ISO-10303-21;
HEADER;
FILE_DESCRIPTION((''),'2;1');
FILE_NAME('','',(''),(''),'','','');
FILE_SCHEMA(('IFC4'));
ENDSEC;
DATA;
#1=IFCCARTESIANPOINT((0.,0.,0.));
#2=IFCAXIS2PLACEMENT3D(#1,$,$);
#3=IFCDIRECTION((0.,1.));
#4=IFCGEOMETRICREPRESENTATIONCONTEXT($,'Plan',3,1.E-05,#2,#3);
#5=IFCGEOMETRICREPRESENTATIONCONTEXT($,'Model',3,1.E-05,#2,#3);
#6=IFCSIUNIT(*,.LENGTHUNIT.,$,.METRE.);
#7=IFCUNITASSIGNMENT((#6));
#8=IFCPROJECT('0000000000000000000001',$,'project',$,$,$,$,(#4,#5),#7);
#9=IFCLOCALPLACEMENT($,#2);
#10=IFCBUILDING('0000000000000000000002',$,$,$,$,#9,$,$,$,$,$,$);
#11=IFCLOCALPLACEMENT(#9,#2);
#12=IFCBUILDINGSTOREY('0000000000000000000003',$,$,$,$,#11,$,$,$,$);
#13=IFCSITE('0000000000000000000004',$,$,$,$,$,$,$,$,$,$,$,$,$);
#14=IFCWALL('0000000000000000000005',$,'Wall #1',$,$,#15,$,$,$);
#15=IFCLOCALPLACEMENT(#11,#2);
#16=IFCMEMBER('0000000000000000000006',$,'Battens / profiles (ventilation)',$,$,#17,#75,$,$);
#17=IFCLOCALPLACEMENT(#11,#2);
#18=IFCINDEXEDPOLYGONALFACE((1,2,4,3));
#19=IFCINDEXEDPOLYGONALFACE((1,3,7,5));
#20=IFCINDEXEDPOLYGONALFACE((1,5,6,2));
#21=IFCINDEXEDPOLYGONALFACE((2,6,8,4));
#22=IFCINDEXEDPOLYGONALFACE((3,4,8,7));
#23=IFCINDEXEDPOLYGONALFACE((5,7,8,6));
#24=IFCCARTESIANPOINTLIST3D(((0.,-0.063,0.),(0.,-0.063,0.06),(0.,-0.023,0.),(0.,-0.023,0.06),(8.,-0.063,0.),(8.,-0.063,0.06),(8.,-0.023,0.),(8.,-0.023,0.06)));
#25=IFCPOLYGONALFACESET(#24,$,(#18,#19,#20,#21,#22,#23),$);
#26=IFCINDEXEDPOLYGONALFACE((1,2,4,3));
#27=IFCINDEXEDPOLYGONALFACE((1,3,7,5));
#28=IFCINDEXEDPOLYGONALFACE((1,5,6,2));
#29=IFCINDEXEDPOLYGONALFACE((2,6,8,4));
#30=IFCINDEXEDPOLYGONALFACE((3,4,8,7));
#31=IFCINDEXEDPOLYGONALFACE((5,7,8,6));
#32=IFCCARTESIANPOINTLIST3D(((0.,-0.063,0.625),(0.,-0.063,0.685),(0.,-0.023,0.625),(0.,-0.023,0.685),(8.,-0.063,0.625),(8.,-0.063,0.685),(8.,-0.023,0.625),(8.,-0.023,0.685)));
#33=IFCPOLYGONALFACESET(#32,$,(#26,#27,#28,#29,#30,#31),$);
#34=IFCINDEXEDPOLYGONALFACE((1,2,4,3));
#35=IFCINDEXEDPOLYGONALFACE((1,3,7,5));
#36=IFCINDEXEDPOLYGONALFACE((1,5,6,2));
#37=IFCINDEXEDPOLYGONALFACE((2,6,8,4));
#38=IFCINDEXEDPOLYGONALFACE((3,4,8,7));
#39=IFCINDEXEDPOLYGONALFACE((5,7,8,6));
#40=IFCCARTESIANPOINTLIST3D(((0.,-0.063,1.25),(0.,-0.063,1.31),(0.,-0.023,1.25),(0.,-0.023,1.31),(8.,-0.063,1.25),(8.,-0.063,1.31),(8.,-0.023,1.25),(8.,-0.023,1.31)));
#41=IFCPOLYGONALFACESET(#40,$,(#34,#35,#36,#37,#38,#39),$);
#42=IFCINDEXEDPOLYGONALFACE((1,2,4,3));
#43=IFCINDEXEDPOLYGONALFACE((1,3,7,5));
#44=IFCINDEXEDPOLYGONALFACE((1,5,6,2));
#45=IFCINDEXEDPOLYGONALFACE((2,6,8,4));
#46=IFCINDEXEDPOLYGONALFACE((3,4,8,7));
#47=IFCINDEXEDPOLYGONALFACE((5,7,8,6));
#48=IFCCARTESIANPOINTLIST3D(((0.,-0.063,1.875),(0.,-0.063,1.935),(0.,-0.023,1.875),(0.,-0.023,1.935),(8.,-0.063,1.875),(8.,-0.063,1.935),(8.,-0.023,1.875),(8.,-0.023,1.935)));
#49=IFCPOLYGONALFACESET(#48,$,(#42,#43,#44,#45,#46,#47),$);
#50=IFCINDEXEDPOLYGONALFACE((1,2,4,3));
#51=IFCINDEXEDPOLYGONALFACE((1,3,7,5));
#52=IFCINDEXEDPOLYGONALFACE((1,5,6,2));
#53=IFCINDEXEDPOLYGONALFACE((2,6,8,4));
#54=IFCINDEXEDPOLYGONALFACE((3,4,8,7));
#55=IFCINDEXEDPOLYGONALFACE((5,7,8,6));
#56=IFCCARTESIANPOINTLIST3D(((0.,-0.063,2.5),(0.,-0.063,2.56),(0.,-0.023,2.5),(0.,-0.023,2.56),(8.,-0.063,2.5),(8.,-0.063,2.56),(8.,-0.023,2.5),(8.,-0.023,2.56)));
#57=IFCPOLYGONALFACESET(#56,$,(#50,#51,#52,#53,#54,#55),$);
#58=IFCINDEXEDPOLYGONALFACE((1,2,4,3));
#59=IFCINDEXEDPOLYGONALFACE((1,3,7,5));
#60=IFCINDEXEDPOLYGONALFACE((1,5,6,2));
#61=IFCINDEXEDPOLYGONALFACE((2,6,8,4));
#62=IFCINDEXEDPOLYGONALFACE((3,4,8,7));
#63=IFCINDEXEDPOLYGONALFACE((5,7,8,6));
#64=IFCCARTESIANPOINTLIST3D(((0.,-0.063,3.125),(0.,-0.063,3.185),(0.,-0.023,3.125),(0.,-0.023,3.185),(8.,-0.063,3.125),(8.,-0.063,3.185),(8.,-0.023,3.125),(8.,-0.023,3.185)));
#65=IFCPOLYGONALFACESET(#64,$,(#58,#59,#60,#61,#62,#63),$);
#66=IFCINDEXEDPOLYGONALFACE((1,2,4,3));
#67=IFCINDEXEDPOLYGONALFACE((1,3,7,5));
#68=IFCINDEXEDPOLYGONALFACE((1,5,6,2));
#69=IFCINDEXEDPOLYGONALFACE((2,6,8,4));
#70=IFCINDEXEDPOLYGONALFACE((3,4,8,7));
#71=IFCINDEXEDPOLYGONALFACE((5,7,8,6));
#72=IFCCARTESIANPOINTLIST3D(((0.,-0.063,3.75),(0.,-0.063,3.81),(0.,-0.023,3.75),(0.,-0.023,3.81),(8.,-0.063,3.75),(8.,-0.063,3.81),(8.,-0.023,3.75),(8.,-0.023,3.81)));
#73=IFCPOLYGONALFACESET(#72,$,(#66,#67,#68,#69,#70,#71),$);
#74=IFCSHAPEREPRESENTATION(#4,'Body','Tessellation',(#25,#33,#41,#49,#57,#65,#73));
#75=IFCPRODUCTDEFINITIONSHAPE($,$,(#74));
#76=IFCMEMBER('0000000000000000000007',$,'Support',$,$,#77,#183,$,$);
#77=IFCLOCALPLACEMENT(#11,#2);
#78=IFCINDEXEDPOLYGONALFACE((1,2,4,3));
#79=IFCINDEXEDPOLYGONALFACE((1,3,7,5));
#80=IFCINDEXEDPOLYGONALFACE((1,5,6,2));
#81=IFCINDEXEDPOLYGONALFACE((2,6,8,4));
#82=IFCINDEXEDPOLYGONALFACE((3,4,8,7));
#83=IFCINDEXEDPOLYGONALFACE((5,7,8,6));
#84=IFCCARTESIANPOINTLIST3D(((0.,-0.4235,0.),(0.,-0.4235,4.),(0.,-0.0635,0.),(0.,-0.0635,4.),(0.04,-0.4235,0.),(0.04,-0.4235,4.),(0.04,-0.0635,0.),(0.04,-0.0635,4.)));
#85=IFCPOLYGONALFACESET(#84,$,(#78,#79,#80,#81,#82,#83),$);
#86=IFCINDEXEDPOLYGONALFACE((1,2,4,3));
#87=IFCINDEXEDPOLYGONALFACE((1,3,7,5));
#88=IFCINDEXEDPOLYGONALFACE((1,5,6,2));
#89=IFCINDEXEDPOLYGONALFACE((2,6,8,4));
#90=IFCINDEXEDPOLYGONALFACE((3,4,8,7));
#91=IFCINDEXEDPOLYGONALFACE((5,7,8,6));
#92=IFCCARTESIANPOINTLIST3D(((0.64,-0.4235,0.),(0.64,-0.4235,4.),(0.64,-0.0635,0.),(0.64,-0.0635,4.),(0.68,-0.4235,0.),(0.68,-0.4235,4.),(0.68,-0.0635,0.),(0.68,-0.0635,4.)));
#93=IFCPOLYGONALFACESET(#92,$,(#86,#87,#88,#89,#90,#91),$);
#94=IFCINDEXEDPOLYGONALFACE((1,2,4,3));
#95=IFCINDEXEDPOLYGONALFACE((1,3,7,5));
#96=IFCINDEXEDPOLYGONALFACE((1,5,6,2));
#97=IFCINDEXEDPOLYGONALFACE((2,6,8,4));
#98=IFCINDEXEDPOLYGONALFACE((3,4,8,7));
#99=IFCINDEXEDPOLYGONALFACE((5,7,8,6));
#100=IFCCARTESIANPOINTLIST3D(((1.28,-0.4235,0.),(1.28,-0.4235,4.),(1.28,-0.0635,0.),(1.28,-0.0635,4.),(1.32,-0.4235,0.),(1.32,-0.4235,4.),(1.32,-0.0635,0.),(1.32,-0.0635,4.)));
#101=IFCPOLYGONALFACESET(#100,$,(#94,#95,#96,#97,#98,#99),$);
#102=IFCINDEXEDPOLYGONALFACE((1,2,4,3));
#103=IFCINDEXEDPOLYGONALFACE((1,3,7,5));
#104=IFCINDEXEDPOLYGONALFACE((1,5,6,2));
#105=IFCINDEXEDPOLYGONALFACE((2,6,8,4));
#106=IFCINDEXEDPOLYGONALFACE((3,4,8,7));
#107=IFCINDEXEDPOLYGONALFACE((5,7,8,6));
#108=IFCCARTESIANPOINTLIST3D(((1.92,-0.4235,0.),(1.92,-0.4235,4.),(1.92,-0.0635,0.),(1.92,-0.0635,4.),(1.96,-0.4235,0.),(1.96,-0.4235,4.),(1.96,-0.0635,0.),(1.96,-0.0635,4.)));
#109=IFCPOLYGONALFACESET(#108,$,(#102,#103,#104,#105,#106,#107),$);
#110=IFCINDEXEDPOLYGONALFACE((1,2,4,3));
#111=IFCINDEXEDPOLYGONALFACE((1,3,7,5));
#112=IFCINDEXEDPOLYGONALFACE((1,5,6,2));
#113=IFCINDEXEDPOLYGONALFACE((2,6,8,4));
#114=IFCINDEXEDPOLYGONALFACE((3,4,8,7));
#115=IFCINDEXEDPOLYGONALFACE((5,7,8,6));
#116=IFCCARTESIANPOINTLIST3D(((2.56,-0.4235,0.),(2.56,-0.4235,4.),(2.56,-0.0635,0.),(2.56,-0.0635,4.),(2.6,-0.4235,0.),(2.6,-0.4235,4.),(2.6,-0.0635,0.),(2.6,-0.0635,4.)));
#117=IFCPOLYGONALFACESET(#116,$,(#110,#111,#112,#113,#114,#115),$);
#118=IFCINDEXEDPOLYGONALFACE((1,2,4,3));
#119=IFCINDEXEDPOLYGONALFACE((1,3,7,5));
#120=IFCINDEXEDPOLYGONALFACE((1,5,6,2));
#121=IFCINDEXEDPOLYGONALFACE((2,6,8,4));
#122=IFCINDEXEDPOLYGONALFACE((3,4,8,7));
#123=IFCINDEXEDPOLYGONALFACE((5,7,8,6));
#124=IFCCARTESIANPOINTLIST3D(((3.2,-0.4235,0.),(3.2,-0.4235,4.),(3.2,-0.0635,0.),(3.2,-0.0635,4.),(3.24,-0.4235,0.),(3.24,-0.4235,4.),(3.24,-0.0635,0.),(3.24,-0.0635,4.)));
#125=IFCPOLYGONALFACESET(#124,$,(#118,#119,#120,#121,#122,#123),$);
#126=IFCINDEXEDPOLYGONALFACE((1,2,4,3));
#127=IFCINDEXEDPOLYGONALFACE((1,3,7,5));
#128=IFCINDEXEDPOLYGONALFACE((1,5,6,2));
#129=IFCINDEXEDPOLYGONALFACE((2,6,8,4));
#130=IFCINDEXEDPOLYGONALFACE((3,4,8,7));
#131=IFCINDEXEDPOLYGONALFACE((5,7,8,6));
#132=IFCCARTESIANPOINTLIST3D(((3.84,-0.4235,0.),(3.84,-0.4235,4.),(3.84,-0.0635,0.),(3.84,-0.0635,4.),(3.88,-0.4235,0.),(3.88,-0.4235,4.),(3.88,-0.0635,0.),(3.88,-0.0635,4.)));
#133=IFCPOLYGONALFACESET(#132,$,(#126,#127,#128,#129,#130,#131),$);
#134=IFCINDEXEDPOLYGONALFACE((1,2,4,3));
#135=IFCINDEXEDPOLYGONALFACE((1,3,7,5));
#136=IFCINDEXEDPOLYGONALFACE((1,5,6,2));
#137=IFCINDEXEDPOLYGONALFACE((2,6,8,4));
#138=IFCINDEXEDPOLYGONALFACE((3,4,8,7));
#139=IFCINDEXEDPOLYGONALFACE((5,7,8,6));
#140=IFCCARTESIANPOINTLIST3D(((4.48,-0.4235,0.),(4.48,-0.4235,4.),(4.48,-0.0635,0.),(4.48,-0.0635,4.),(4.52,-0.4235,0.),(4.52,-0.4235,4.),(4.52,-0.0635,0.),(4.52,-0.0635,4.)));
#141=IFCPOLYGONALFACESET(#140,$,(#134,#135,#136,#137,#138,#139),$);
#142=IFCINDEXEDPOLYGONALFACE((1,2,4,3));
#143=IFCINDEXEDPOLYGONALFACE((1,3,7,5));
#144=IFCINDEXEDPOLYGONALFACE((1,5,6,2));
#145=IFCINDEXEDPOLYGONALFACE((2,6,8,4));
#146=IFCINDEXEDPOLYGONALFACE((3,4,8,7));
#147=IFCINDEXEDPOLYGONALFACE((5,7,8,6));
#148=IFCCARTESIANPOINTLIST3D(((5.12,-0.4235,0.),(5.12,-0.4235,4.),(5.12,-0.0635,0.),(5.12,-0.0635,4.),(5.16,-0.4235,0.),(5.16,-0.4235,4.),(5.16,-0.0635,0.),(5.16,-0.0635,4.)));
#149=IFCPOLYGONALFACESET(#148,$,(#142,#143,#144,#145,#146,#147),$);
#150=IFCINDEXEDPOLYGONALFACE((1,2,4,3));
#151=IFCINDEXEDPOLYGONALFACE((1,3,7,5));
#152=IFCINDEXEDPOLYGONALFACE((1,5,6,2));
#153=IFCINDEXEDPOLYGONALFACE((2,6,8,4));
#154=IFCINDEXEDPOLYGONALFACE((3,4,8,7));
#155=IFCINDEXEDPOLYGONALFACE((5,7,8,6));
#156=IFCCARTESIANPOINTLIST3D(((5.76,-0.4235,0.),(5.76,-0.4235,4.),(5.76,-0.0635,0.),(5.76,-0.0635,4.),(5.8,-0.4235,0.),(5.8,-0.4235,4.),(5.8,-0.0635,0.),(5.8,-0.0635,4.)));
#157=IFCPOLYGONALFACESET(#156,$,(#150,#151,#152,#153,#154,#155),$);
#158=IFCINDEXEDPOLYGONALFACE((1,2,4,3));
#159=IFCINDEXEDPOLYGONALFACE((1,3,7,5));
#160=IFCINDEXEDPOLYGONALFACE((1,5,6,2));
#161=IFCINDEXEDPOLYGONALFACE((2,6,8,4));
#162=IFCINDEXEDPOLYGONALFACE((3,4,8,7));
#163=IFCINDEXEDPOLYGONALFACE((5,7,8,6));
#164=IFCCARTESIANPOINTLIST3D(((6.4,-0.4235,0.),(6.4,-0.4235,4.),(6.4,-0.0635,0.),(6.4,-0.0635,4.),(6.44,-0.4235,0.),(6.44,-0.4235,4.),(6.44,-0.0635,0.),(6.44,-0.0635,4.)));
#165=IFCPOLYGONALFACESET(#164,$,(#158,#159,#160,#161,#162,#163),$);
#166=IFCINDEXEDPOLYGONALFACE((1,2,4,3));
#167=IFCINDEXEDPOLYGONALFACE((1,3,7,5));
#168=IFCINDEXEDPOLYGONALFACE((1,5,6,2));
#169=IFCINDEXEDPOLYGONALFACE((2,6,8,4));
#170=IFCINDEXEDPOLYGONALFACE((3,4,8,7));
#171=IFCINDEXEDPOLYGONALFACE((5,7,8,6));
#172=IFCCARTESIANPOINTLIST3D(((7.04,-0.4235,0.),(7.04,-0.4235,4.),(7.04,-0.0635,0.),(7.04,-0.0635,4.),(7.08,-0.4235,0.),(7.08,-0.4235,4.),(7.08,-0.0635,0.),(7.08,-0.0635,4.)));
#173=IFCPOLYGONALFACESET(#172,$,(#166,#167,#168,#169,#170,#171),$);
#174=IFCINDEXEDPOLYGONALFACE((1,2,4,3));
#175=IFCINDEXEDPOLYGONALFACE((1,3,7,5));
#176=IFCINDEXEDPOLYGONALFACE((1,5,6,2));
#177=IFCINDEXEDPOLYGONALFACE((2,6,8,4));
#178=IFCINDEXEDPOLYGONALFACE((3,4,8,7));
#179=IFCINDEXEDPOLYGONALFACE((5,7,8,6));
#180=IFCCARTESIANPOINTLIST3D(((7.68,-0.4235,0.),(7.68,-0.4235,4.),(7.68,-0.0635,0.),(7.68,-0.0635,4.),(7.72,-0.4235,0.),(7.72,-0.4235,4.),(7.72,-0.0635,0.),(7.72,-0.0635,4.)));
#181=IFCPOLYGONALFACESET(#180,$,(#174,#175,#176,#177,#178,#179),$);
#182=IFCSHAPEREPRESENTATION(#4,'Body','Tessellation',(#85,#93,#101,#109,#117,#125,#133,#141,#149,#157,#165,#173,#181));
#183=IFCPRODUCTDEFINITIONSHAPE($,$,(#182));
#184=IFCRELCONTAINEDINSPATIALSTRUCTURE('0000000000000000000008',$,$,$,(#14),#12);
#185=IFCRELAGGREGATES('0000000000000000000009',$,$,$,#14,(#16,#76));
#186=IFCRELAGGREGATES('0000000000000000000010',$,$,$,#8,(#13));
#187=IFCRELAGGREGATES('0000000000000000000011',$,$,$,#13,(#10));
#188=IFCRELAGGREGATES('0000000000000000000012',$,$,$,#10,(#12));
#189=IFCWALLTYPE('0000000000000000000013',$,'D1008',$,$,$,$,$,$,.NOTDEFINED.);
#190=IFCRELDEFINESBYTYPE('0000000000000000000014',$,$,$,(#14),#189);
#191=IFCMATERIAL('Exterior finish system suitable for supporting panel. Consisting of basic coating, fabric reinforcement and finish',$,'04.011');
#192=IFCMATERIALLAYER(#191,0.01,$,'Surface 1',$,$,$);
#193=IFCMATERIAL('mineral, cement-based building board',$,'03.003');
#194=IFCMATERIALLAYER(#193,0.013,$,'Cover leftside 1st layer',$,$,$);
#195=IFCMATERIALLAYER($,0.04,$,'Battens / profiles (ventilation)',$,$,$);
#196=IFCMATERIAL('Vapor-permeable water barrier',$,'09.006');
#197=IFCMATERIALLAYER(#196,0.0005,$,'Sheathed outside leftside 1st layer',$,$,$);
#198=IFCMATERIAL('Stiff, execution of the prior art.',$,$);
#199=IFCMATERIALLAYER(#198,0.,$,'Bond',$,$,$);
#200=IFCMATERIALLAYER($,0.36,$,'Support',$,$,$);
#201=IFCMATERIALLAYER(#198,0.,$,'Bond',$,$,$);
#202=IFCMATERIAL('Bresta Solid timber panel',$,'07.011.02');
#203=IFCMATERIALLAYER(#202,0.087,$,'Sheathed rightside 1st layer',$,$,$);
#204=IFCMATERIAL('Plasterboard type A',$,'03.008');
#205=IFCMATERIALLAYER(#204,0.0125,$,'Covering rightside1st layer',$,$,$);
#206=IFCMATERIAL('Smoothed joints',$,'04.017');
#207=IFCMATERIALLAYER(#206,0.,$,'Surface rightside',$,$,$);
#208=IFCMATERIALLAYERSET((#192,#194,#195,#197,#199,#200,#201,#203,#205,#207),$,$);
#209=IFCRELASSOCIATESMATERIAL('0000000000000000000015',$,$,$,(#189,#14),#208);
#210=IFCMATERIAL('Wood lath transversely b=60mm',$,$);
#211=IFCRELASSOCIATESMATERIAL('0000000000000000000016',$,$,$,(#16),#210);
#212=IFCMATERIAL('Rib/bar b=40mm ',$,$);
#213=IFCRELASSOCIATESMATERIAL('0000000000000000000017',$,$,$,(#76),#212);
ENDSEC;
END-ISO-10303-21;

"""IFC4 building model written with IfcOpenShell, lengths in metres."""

from ifc_helpers import new_model, si_unit, direction, frame, frame_2d, origin, place, context, project, spatial, rectangle, extrude, material, layer, layer_set, type_object, element, aggregate, save


model = new_model("IFC4")

# Units and contexts
plan_context = context("Plan", 3, precision=1e-05, world=origin(), true_north=direction((0.0, 1.0)))
model_context = context("Model", 3, precision=1e-05, world=origin(), true_north=direction((0.0, 1.0)))
ifc_project = project(units=[si_unit("LENGTHUNIT", "METRE")], contexts=[plan_context, model_context])

# Site, building, storey
site = spatial("IfcSite", under=ifc_project)
building_placement = place(None, origin())
building = spatial("IfcBuilding", under=site, at=building_placement)
storey_placement = place(building_placement, origin())
storey = spatial("IfcBuildingStorey", under=building, at=storey_placement)

# Wall, members
ifc_material_1 = material(Name="Exterior finish system suitable for supporting panel. Consisting of basic coating, fabric reinforcement and finish", Category="04.011")
ifc_layer_1 = layer(ifc_material_1, 0.01, Name="Surface 1")
ifc_material_2 = material(Name="mineral, cement-based building board", Category="03.003")
ifc_layer_2 = layer(ifc_material_2, 0.013, Name="Cover leftside 1st layer")
ifc_layer_3 = layer(None, 0.04, Name="Battens / profiles (ventilation)")
ifc_material_3 = material(Name="Vapor-permeable water barrier", Category="09.006")
ifc_layer_4 = layer(ifc_material_3, 0.0005, Name="Sheathed outside leftside 1st layer")
ifc_material_4 = material(Name="Stiff, execution of the prior art.")
ifc_layer_5 = layer(ifc_material_4, 0.0, Name="Bond")
ifc_layer_6 = layer(None, 0.36, Name="Support")
ifc_layer_7 = layer(ifc_material_4, 0.0, Name="Bond")
ifc_material_5 = material(Name="Bresta Solid timber panel", Category="07.011.02")
ifc_layer_8 = layer(ifc_material_5, 0.087, Name="Sheathed rightside 1st layer")
ifc_material_6 = material(Name="Plasterboard type A", Category="03.008")
ifc_layer_9 = layer(ifc_material_6, 0.0125, Name="Covering rightside1st layer")
ifc_material_7 = material(Name="Smoothed joints", Category="04.017")
ifc_layer_10 = layer(ifc_material_7, 0.0, Name="Surface rightside")
ifc_layer_set = layer_set([ifc_layer_1, ifc_layer_2, ifc_layer_3, ifc_layer_4, ifc_layer_5, ifc_layer_6, ifc_layer_7, ifc_layer_8, ifc_layer_9, ifc_layer_10])
wall_type = type_object("IfcWallType", Name="D1008", PredefinedType="NOTDEFINED", material=ifc_layer_set)
wall_placement = place(None, frame((0.0, 0.0, 0.0), z_axis=(0.0, -1.0, 0.0), x_axis=(1.0, 0.0, 0.0)))
wall = element("IfcWall", 1, at=wall_placement, inside=storey, type_object=wall_type, material=ifc_layer_set, Name="Wall #1")
ifc_material_8 = material(Name="Wood lath transversely b=60mm")
member_1_placement = place(wall_placement, origin())
member_1 = element("IfcMember", 2, at=member_1_placement, material=ifc_material_8, Name="Battens / profiles (ventilation)", context=plan_context, shape_type="SweptSolid", body=[
    extrude(rectangle(XDim=0.06, YDim=0.04, at=frame_2d((0.03, 0.02), x_axis=(1.0, 0.0))), frame((0.0, 0.0, 0.023), z_axis=(1.0, 0.0, 0.0), x_axis=(0.0, 1.0, 0.0)), (0.0, 0.0, 1.0), 8.0),
    extrude(rectangle(XDim=0.06, YDim=0.04, at=frame_2d((0.03, 0.02), x_axis=(1.0, 0.0))), frame((0.0, 0.625, 0.023), z_axis=(1.0, 0.0, 0.0), x_axis=(0.0, 1.0, 0.0)), (0.0, 0.0, 1.0), 8.0),
    extrude(rectangle(XDim=0.06, YDim=0.04, at=frame_2d((0.03, 0.02), x_axis=(1.0, 0.0))), frame((0.0, 1.25, 0.023), z_axis=(1.0, 0.0, 0.0), x_axis=(0.0, 1.0, 0.0)), (0.0, 0.0, 1.0), 8.0),
    extrude(rectangle(XDim=0.06, YDim=0.04, at=frame_2d((0.03, 0.02), x_axis=(1.0, 0.0))), frame((0.0, 1.875, 0.023), z_axis=(1.0, 0.0, 0.0), x_axis=(0.0, 1.0, 0.0)), (0.0, 0.0, 1.0), 8.0),
    extrude(rectangle(XDim=0.06, YDim=0.04, at=frame_2d((0.03, 0.02), x_axis=(1.0, 0.0))), frame((0.0, 2.5, 0.023), z_axis=(1.0, 0.0, 0.0), x_axis=(0.0, 1.0, 0.0)), (0.0, 0.0, 1.0), 8.0),
    extrude(rectangle(XDim=0.06, YDim=0.04, at=frame_2d((0.03, 0.02), x_axis=(1.0, 0.0))), frame((0.0, 3.125, 0.023), z_axis=(1.0, 0.0, 0.0), x_axis=(0.0, 1.0, 0.0)), (0.0, 0.0, 1.0), 8.0),
    extrude(rectangle(XDim=0.06, YDim=0.04, at=frame_2d((0.03, 0.02), x_axis=(1.0, 0.0))), frame((0.0, 3.75, 0.023), z_axis=(1.0, 0.0, 0.0), x_axis=(0.0, 1.0, 0.0)), (0.0, 0.0, 1.0), 8.0),
])
ifc_material_9 = material(Name="Rib/bar b=40mm ")
member_2_placement = place(wall_placement, origin())
member_2 = element("IfcMember", 3, at=member_2_placement, material=ifc_material_9, Name="Support", context=plan_context, shape_type="SweptSolid", body=[
    extrude(rectangle(XDim=0.04, YDim=0.36, at=frame_2d((0.02, 0.18), x_axis=(1.0, 0.0))), frame((0.0, 4.0, 0.0635), z_axis=(0.0, -1.0, 0.0), x_axis=(1.0, 0.0, 0.0)), (0.0, 0.0, 1.0), 4.0),
    extrude(rectangle(XDim=0.04, YDim=0.36, at=frame_2d((0.02, 0.18), x_axis=(1.0, 0.0))), frame((0.64, 4.0, 0.0635), z_axis=(0.0, -1.0, 0.0), x_axis=(1.0, 0.0, 0.0)), (0.0, 0.0, 1.0), 4.0),
    extrude(rectangle(XDim=0.04, YDim=0.36, at=frame_2d((0.02, 0.18), x_axis=(1.0, 0.0))), frame((1.28, 4.0, 0.0635), z_axis=(0.0, -1.0, 0.0), x_axis=(1.0, 0.0, 0.0)), (0.0, 0.0, 1.0), 4.0),
    extrude(rectangle(XDim=0.04, YDim=0.36, at=frame_2d((0.02, 0.18), x_axis=(1.0, 0.0))), frame((1.92, 4.0, 0.0635), z_axis=(0.0, -1.0, 0.0), x_axis=(1.0, 0.0, 0.0)), (0.0, 0.0, 1.0), 4.0),
    extrude(rectangle(XDim=0.04, YDim=0.36, at=frame_2d((0.02, 0.18), x_axis=(1.0, 0.0))), frame((2.56, 4.0, 0.0635), z_axis=(0.0, -1.0, 0.0), x_axis=(1.0, 0.0, 0.0)), (0.0, 0.0, 1.0), 4.0),
    extrude(rectangle(XDim=0.04, YDim=0.36, at=frame_2d((0.02, 0.18), x_axis=(1.0, 0.0))), frame((3.2, 4.0, 0.0635), z_axis=(0.0, -1.0, 0.0), x_axis=(1.0, 0.0, 0.0)), (0.0, 0.0, 1.0), 4.0),
    extrude(rectangle(XDim=0.04, YDim=0.36, at=frame_2d((0.02, 0.18), x_axis=(1.0, 0.0))), frame((3.84, 4.0, 0.0635), z_axis=(0.0, -1.0, 0.0), x_axis=(1.0, 0.0, 0.0)), (0.0, 0.0, 1.0), 4.0),
    extrude(rectangle(XDim=0.04, YDim=0.36, at=frame_2d((0.02, 0.18), x_axis=(1.0, 0.0))), frame((4.48, 4.0, 0.0635), z_axis=(0.0, -1.0, 0.0), x_axis=(1.0, 0.0, 0.0)), (0.0, 0.0, 1.0), 4.0),
    extrude(rectangle(XDim=0.04, YDim=0.36, at=frame_2d((0.02, 0.18), x_axis=(1.0, 0.0))), frame((5.12, 4.0, 0.0635), z_axis=(0.0, -1.0, 0.0), x_axis=(1.0, 0.0, 0.0)), (0.0, 0.0, 1.0), 4.0),
    extrude(rectangle(XDim=0.04, YDim=0.36, at=frame_2d((0.02, 0.18), x_axis=(1.0, 0.0))), frame((5.76, 4.0, 0.0635), z_axis=(0.0, -1.0, 0.0), x_axis=(1.0, 0.0, 0.0)), (0.0, 0.0, 1.0), 4.0),
    extrude(rectangle(XDim=0.04, YDim=0.36, at=frame_2d((0.02, 0.18), x_axis=(1.0, 0.0))), frame((6.4, 4.0, 0.0635), z_axis=(0.0, -1.0, 0.0), x_axis=(1.0, 0.0, 0.0)), (0.0, 0.0, 1.0), 4.0),
    extrude(rectangle(XDim=0.04, YDim=0.36, at=frame_2d((0.02, 0.18), x_axis=(1.0, 0.0))), frame((7.04, 4.0, 0.0635), z_axis=(0.0, -1.0, 0.0), x_axis=(1.0, 0.0, 0.0)), (0.0, 0.0, 1.0), 4.0),
    extrude(rectangle(XDim=0.04, YDim=0.36, at=frame_2d((0.02, 0.18), x_axis=(1.0, 0.0))), frame((7.68, 4.0, 0.0635), z_axis=(0.0, -1.0, 0.0), x_axis=(1.0, 0.0, 0.0)), (0.0, 0.0, 1.0), 4.0),
])
aggregate(wall, [member_1, member_2])

save(model, "model.ifc")
